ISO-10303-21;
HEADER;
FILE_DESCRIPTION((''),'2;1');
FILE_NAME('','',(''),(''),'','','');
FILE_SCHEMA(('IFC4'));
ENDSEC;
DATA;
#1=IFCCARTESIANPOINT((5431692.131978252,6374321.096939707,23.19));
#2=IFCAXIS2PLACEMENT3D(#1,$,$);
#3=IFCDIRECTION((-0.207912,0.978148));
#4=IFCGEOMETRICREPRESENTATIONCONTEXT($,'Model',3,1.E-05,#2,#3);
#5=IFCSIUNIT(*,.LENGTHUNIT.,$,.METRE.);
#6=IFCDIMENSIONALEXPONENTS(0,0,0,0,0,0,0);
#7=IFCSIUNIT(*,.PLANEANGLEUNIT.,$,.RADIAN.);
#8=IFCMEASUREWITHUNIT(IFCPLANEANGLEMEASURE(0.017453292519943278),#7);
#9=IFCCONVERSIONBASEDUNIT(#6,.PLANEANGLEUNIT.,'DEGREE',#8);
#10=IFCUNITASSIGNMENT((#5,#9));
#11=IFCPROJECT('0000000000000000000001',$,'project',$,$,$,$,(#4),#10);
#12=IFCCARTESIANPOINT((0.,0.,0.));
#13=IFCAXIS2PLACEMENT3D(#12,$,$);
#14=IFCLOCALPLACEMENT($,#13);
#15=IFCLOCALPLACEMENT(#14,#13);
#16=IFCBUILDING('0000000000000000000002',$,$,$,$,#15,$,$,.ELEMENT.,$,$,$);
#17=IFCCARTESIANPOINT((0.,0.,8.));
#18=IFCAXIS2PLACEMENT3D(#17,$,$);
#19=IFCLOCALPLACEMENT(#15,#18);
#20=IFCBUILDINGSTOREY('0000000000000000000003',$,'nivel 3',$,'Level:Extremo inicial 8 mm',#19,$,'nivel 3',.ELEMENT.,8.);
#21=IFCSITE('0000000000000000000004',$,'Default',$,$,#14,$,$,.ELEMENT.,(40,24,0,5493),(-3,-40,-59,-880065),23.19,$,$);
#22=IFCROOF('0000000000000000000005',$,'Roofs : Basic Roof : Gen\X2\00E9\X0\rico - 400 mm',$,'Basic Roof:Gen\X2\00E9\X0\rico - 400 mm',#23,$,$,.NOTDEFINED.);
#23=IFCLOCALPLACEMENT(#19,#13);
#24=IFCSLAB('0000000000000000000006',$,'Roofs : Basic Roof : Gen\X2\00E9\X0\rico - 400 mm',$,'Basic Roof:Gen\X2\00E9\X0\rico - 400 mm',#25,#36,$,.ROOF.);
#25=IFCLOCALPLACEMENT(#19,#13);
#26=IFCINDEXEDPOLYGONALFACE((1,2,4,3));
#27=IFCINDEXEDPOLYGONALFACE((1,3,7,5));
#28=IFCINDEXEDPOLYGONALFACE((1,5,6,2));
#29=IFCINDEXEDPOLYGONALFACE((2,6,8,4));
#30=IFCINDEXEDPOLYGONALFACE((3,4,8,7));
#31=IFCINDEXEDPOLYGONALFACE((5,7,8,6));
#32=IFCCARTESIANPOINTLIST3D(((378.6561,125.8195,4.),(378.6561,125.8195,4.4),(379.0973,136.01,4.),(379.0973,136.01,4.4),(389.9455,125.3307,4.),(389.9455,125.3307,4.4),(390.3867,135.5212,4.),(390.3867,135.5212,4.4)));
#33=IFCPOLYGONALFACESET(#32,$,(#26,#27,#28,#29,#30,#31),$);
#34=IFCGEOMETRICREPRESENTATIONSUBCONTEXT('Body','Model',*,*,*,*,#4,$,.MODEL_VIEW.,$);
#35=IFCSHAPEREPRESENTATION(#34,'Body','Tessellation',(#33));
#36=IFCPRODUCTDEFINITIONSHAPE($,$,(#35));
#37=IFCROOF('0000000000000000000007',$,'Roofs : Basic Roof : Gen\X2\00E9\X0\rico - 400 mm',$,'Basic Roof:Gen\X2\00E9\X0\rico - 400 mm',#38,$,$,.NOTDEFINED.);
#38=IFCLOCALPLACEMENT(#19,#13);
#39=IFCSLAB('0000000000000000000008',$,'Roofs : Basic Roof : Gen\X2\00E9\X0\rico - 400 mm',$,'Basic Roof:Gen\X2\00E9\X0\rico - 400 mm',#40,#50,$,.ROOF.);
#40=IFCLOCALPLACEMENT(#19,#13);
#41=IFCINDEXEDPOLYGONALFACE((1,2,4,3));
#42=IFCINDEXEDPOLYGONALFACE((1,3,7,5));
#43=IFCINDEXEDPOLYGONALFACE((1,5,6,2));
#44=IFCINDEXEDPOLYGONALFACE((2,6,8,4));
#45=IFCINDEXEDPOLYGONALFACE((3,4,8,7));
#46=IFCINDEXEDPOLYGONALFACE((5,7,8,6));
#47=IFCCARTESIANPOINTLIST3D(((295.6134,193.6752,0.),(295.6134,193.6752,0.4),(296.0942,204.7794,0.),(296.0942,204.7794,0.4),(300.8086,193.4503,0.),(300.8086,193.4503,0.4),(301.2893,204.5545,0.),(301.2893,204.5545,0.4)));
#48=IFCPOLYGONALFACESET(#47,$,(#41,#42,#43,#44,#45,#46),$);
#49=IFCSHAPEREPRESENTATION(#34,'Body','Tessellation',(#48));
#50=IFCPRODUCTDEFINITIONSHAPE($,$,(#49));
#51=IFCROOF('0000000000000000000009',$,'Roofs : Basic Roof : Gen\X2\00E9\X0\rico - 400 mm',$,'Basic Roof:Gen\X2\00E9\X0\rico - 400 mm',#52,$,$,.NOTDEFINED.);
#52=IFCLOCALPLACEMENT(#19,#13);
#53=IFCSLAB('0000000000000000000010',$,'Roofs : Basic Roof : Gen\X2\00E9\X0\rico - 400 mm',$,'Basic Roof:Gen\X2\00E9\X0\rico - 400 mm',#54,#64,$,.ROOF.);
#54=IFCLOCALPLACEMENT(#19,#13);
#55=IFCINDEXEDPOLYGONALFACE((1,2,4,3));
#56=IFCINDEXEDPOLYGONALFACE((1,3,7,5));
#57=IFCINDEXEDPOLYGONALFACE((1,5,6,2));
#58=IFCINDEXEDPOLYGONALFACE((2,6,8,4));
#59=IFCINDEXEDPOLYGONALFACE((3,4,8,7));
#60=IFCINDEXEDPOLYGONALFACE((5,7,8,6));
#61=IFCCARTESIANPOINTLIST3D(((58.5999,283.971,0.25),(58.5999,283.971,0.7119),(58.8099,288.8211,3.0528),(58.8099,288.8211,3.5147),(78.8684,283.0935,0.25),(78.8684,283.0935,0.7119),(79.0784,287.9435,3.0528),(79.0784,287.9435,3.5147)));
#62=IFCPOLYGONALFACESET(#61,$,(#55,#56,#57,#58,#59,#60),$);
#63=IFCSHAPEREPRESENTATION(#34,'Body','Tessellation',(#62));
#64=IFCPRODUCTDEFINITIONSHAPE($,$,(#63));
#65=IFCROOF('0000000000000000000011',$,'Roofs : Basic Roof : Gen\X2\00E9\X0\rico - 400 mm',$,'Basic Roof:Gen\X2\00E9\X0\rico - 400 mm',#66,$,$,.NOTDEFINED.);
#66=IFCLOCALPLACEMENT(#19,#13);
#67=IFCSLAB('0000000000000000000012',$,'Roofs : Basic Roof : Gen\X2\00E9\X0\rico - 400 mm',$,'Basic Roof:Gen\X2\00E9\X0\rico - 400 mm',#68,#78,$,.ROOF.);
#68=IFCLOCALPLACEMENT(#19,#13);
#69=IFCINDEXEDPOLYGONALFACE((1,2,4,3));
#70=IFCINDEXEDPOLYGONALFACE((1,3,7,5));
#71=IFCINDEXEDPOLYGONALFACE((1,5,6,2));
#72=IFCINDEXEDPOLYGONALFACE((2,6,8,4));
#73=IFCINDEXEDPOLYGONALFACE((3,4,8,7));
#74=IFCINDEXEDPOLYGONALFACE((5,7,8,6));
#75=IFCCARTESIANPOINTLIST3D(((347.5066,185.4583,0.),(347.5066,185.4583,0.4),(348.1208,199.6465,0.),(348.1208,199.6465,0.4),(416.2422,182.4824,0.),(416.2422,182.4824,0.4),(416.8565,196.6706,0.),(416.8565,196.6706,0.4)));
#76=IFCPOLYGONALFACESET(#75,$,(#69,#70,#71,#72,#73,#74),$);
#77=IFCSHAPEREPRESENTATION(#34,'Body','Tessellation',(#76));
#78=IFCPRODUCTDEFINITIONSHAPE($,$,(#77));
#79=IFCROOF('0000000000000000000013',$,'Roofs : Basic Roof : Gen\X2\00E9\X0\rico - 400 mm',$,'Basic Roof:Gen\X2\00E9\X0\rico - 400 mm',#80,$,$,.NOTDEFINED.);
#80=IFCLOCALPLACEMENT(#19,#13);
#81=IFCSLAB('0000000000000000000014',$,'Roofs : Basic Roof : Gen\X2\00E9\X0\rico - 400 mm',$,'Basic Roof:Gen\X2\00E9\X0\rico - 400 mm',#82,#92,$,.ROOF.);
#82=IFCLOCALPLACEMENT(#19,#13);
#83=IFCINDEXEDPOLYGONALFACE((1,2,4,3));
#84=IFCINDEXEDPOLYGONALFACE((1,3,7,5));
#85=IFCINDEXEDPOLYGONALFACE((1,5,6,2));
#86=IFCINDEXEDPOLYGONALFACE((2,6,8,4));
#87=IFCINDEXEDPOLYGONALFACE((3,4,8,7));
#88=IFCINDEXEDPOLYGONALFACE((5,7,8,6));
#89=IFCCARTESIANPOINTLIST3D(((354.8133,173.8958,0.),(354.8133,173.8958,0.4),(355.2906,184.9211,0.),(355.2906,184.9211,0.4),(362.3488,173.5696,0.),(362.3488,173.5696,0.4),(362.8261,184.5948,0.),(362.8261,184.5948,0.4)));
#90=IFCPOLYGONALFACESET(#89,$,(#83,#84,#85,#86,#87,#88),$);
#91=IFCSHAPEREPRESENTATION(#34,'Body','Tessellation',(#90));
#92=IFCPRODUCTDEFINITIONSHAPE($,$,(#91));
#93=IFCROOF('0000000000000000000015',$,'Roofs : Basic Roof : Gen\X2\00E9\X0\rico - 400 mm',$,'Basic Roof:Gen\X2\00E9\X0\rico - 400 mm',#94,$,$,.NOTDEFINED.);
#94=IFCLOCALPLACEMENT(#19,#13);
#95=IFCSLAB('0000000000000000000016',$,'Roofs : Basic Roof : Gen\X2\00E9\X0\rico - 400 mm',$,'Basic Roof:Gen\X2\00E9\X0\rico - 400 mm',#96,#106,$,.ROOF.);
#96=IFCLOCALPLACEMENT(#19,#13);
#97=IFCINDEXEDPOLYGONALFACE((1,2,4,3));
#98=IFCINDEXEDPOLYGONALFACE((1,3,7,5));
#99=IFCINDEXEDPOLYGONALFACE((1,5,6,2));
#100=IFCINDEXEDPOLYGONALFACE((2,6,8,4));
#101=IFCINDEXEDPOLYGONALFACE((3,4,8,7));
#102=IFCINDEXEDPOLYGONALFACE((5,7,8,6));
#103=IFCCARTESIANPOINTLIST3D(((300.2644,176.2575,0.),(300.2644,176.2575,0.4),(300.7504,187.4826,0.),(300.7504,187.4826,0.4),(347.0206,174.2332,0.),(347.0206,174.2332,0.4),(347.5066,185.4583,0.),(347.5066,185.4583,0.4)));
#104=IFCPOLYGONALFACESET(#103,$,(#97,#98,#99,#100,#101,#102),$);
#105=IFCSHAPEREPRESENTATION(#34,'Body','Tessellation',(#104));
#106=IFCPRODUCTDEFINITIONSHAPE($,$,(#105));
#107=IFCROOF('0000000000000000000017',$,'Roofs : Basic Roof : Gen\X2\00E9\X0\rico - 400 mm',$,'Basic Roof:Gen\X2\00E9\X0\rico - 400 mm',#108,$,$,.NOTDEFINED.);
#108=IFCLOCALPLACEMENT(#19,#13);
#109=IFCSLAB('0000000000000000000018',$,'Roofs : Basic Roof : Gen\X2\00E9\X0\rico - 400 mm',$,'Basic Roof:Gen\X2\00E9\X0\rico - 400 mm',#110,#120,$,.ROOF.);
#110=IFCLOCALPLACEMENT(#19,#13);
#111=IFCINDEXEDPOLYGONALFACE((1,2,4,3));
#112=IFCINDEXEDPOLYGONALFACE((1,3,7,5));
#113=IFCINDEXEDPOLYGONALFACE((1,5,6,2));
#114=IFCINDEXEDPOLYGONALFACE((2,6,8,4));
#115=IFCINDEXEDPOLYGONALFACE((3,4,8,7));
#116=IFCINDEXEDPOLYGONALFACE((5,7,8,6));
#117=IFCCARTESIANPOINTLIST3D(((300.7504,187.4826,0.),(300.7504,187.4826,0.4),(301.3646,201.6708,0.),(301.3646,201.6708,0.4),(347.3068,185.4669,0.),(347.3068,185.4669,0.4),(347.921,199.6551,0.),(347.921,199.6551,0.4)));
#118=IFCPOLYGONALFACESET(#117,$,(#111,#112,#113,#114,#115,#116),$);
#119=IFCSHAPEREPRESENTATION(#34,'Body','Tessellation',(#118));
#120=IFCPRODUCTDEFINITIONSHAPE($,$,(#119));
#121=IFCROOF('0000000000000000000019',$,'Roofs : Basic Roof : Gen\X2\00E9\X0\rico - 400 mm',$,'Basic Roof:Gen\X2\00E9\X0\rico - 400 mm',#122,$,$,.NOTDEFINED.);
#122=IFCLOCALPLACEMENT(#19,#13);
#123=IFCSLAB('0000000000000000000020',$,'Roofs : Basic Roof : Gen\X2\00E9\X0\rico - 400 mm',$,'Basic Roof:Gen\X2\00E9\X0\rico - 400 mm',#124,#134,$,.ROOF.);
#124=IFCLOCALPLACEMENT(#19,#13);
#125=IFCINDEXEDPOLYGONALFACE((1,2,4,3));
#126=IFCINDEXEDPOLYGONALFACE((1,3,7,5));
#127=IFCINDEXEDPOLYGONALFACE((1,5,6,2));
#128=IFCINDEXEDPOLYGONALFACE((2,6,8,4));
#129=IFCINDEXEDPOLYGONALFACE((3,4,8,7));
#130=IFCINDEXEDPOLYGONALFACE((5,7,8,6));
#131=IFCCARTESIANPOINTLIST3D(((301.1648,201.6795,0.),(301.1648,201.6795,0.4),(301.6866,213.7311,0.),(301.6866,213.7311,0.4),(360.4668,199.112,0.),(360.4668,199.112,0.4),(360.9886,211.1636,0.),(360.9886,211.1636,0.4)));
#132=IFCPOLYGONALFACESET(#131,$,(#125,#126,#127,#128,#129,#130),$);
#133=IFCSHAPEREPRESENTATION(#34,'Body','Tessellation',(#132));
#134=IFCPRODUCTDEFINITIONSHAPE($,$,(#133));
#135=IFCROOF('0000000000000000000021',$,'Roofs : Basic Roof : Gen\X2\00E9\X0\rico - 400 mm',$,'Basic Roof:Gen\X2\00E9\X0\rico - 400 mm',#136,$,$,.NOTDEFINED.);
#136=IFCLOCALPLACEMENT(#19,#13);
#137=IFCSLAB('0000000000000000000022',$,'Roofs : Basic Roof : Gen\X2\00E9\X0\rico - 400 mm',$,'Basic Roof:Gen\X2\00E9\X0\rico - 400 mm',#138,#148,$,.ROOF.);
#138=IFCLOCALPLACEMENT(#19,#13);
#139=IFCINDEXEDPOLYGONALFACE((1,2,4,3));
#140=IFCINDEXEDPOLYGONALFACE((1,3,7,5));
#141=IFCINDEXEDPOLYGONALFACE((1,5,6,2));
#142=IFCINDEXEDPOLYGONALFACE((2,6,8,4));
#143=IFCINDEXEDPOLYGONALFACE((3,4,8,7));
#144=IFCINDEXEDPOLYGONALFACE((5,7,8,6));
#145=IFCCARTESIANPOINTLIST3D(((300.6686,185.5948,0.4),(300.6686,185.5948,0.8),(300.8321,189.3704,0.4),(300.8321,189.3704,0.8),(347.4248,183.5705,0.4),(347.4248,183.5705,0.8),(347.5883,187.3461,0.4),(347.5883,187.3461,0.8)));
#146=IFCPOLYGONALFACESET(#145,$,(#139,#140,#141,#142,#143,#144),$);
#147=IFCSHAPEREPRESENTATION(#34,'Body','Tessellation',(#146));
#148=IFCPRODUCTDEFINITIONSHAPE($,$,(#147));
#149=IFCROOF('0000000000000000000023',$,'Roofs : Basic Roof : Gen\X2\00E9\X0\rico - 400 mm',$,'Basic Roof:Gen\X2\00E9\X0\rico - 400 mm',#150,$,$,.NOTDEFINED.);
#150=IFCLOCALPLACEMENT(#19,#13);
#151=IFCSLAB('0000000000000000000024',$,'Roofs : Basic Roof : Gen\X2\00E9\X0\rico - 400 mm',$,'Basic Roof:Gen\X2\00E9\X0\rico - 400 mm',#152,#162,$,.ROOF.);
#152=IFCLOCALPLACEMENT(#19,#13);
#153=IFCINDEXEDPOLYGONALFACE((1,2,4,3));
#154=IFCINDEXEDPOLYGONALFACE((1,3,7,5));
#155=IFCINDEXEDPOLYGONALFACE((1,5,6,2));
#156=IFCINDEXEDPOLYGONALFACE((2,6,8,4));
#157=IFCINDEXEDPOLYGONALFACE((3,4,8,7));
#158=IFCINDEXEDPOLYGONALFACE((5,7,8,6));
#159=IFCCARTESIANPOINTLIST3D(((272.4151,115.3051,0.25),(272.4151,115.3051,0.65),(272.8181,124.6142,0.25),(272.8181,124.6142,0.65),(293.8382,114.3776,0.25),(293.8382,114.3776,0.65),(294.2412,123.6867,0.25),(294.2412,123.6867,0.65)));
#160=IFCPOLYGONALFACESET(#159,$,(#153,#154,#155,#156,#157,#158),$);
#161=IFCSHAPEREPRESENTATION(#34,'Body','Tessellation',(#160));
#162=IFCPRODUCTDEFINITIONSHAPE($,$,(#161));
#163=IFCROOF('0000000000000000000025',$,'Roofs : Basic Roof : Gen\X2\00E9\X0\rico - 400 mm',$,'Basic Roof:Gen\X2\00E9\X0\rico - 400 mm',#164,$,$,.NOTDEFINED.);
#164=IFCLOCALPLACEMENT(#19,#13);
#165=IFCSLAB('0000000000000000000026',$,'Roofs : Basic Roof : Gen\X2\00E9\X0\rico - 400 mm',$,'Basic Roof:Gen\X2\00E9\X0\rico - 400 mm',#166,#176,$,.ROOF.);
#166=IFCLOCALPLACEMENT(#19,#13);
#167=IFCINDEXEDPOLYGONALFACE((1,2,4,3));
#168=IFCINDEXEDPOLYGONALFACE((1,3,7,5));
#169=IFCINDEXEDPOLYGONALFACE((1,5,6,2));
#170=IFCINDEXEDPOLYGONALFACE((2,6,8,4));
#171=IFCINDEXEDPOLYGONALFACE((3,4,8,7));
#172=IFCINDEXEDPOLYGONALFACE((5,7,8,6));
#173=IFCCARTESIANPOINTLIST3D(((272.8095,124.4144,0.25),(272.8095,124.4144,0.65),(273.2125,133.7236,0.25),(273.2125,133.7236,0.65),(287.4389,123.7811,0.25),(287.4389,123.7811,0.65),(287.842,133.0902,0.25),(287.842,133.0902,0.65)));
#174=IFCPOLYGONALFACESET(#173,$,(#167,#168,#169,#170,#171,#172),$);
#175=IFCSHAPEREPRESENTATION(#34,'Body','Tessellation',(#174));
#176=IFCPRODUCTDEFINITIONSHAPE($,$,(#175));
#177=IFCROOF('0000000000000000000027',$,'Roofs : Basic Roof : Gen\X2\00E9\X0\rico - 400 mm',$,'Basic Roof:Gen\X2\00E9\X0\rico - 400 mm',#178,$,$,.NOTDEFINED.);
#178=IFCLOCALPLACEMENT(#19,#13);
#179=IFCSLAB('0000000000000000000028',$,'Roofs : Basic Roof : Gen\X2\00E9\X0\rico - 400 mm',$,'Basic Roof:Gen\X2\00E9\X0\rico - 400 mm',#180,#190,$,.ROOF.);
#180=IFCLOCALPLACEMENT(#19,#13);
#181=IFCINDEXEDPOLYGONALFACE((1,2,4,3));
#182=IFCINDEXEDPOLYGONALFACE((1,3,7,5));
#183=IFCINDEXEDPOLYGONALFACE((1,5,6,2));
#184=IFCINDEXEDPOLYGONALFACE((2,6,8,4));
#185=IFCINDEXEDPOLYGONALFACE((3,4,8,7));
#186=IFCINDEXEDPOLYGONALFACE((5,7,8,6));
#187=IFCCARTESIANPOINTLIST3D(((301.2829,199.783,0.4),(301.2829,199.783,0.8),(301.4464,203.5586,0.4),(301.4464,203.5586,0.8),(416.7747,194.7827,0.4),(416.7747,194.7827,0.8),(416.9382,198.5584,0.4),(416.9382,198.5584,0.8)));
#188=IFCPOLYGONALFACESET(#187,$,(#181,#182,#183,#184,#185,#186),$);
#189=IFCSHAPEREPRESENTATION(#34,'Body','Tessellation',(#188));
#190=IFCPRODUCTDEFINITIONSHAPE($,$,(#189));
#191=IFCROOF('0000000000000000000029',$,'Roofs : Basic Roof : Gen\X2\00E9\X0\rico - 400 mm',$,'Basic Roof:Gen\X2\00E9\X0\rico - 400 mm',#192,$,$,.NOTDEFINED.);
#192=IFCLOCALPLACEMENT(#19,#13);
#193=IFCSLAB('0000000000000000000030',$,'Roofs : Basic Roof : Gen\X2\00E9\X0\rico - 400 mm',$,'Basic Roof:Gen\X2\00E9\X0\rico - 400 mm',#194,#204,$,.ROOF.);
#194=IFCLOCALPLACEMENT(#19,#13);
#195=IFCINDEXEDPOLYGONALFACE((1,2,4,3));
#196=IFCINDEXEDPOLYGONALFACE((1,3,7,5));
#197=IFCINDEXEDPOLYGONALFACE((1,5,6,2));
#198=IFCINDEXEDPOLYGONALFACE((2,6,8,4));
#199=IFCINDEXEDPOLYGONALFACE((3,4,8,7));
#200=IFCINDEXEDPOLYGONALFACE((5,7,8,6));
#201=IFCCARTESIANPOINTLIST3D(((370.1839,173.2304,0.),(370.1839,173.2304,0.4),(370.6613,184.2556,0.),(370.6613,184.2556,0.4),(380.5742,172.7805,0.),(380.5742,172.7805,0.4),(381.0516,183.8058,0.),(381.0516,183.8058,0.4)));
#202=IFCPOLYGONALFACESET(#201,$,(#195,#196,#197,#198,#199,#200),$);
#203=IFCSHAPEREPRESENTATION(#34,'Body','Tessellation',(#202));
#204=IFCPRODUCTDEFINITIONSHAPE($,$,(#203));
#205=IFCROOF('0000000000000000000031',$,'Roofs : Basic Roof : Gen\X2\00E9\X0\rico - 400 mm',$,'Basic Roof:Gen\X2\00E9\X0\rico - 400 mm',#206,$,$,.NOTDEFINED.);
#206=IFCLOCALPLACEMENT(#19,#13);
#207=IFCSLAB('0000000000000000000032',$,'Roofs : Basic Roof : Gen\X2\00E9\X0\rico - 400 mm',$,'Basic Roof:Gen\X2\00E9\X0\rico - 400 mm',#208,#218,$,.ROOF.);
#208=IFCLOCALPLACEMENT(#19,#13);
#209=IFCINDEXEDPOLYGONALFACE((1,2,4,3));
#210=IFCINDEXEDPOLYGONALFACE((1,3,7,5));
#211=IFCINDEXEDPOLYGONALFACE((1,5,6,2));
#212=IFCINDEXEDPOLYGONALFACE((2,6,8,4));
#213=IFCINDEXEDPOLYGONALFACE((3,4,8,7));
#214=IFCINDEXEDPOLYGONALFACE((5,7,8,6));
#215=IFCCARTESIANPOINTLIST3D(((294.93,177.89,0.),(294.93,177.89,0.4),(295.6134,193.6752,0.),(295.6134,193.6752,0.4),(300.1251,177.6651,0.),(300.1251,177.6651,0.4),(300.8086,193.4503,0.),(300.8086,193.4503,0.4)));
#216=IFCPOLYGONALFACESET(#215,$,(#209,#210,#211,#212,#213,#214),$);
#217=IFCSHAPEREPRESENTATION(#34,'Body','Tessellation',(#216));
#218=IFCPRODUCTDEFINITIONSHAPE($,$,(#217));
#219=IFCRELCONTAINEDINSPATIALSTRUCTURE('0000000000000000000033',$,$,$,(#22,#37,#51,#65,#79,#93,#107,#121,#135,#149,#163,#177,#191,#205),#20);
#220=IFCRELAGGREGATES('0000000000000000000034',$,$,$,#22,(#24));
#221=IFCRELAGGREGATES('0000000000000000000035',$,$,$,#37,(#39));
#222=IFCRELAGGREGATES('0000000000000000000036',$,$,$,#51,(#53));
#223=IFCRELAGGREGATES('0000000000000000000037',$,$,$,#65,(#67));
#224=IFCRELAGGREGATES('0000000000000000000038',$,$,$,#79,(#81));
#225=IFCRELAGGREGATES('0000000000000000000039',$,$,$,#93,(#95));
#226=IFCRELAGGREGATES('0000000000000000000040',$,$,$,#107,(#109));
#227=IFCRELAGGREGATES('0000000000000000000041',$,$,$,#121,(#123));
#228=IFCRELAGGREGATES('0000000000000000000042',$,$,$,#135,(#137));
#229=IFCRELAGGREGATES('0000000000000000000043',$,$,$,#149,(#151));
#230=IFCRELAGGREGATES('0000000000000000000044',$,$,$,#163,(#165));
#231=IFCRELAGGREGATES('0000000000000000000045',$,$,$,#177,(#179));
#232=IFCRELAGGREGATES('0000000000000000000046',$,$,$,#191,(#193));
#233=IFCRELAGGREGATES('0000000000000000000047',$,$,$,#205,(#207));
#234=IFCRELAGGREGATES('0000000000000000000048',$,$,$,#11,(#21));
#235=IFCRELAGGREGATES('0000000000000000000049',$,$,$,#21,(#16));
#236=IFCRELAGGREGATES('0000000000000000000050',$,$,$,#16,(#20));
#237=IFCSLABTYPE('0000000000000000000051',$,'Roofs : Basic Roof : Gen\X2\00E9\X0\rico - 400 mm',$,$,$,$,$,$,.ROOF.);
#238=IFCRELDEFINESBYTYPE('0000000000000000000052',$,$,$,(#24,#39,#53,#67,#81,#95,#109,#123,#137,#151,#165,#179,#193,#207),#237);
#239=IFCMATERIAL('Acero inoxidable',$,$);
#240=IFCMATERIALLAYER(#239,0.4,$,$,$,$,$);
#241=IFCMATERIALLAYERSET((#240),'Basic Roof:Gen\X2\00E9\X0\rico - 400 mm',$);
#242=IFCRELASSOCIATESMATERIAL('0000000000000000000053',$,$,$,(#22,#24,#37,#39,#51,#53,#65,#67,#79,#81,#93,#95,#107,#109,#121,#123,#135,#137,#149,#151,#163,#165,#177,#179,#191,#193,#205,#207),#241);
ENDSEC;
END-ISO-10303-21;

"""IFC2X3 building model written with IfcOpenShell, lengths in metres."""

from ifc_helpers import new_model, entity, si_unit, converted_unit, direction, frame, frame_2d, origin, place, context, subcontext, project, spatial, rectangle, extrude, material, layer, layer_set, type_object, element, aggregate, save


model = new_model("IFC2X3")

# Units and contexts
model_context = context("Model", 3, precision=1e-05, world=frame((5431692.131978252, 6374321.096939707, 23.19)), true_north=direction((-0.207912, 0.978148)))
body_context = subcontext(model_context, "Body", "Model", "MODEL_VIEW")
ifc_project = project(units=[si_unit("LENGTHUNIT", "METRE"), converted_unit("PLANEANGLEUNIT", "DEGREE", entity("IfcPlaneAngleMeasure", 0.017453292519943278), si_unit("PLANEANGLEUNIT", "RADIAN"), dimensions=[0, 0, 0, 0, 0, 0, 0])], contexts=[model_context])

# Site, building, storey
site_placement = place(None, origin())
site = spatial("IfcSite", under=ifc_project, at=site_placement, Name="Default", CompositionType="ELEMENT", RefLatitude=(40, 24, 0, 5493), RefLongitude=(-3, -40, -59, -880065), RefElevation=23.19)
building_placement = place(site_placement, origin())
building = spatial("IfcBuilding", under=site, at=building_placement, CompositionType="ELEMENT")
storey_placement = place(building_placement, frame((0.0, 0.0, 8.0)))
storey = spatial("IfcBuildingStorey", under=building, at=storey_placement, Name="nivel 3", ObjectType="Level:Extremo inicial 8 mm", LongName="nivel 3", CompositionType="ELEMENT", Elevation=8.0)

# Roofs, slabs
ifc_material_1 = material(Name="Acero inoxidable")
ifc_layer = layer(ifc_material_1, 0.4)
ifc_layer_set = layer_set([ifc_layer], Name="Basic Roof:Genérico - 400 mm")
roof_1_placement = place(storey_placement, frame((378.6561, 125.3307, 4.0)))
roof_1 = element("IfcRoof", 1, at=roof_1_placement, inside=storey, material=ifc_layer_set, Name="Roofs : Basic Roof : Genérico - 400 mm", ObjectType="Basic Roof:Genérico - 400 mm", ShapeType="NOTDEFINED")
slab_type = type_object("IfcSlabType", Name="Roofs : Basic Roof : Genérico - 400 mm", PredefinedType="ROOF")
slab_1_placement = place(roof_1_placement, origin())
slab_1 = element("IfcSlab", 2, at=slab_1_placement, type_object=slab_type, material=ifc_layer_set, Name="Roofs : Basic Roof : Genérico - 400 mm", ObjectType="Basic Roof:Genérico - 400 mm", PredefinedType="ROOF", context=body_context, shape_type="SweptSolid", body=[
    extrude(rectangle(XDim=10.2, YDim=11.3, at=frame_2d((0.0, 0.0), x_axis=(0.043255, 0.999064))), frame((5.8653, 5.3396, 0.0)), (0.0, 0.0, 1.0), 0.4),
])
aggregate(roof_1, [slab_1])
roof_2_placement = place(storey_placement, frame((295.6134, 193.4503, 0.0)))
roof_2 = element("IfcRoof", 3, at=roof_2_placement, inside=storey, material=ifc_layer_set, Name="Roofs : Basic Roof : Genérico - 400 mm", ObjectType="Basic Roof:Genérico - 400 mm", ShapeType="NOTDEFINED")
slab_2_placement = place(roof_2_placement, origin())
slab_2 = element("IfcSlab", 4, at=slab_2_placement, type_object=slab_type, material=ifc_layer_set, Name="Roofs : Basic Roof : Genérico - 400 mm", ObjectType="Basic Roof:Genérico - 400 mm", PredefinedType="ROOF", context=body_context, shape_type="SweptSolid", body=[
    extrude(rectangle(XDim=11.1146, YDim=5.2, at=frame_2d((0.0, 0.0), x_axis=(-0.043255, -0.999064))), frame((2.8379, 5.6646, 0.0)), (0.0, 0.0, 1.0), 0.4),
])
aggregate(roof_2, [slab_2])

# Roof, slab
roof_3_placement = place(storey_placement, frame((58.5999, 283.0935, 0.25)))
roof_3 = element("IfcRoof", 5, at=roof_3_placement, inside=storey, material=ifc_layer_set, Name="Roofs : Basic Roof : Genérico - 400 mm", ObjectType="Basic Roof:Genérico - 400 mm", ShapeType="NOTDEFINED")
slab_3_placement = place(roof_3_placement, origin())
slab_3 = element("IfcSlab", 6, at=slab_3_placement, type_object=slab_type, material=ifc_layer_set, Name="Roofs : Basic Roof : Genérico - 400 mm", ObjectType="Basic Roof:Genérico - 400 mm", PredefinedType="ROOF", context=body_context, shape_type="SweptSolid", body=[
    extrude(rectangle(XDim=5.6056, YDim=20.2874, at=frame_2d((0.0, 0.0), x_axis=(0.037468, 0.999298))), frame((10.2392, 2.8638, 1.4014), z_axis=(-0.021627, -0.499532, 0.866025), x_axis=(0.999766, -0.010806, 0.018734)), (0.018734, 0.499649, 0.866025), 0.4619),
])
aggregate(roof_3, [slab_3])

# Roofs, slabs
roof_4_placement = place(storey_placement, frame((347.5066, 182.4824, 0.0)))
roof_4 = element("IfcRoof", 7, at=roof_4_placement, inside=storey, material=ifc_layer_set, Name="Roofs : Basic Roof : Genérico - 400 mm", ObjectType="Basic Roof:Genérico - 400 mm", ShapeType="NOTDEFINED")
slab_4_placement = place(roof_4_placement, origin())
slab_4 = element("IfcSlab", 8, at=slab_4_placement, type_object=slab_type, material=ifc_layer_set, Name="Roofs : Basic Roof : Genérico - 400 mm", ObjectType="Basic Roof:Genérico - 400 mm", PredefinedType="ROOF", context=body_context, shape_type="SweptSolid", body=[
    extrude(rectangle(XDim=14.2015, YDim=68.8, at=frame_2d((0.0, 0.0), x_axis=(0.043255, 0.999064))), frame((34.6749, 8.5821, 0.0)), (0.0, 0.0, 1.0), 0.4),
])
aggregate(roof_4, [slab_4])
roof_5_placement = place(storey_placement, frame((354.8133, 173.5696, 0.0)))
roof_5 = element("IfcRoof", 9, at=roof_5_placement, inside=storey, material=ifc_layer_set, Name="Roofs : Basic Roof : Genérico - 400 mm", ObjectType="Basic Roof:Genérico - 400 mm", ShapeType="NOTDEFINED")
slab_5_placement = place(roof_5_placement, origin())
slab_5 = element("IfcSlab", 10, at=slab_5_placement, type_object=slab_type, material=ifc_layer_set, Name="Roofs : Basic Roof : Genérico - 400 mm", ObjectType="Basic Roof:Genérico - 400 mm", PredefinedType="ROOF", context=body_context, shape_type="SweptSolid", body=[
    extrude(rectangle(XDim=11.0356, YDim=7.5425, at=frame_2d((0.0, 0.0), x_axis=(0.043255, 0.999064))), frame((4.0064, 5.6758, 0.0)), (0.0, 0.0, 1.0), 0.4),
])
aggregate(roof_5, [slab_5])
roof_6_placement = place(storey_placement, frame((300.2644, 174.2332, 0.0)))
roof_6 = element("IfcRoof", 11, at=roof_6_placement, inside=storey, material=ifc_layer_set, Name="Roofs : Basic Roof : Genérico - 400 mm", ObjectType="Basic Roof:Genérico - 400 mm", ShapeType="NOTDEFINED")
slab_6_placement = place(roof_6_placement, origin())
slab_6 = element("IfcSlab", 12, at=slab_6_placement, type_object=slab_type, material=ifc_layer_set, Name="Roofs : Basic Roof : Genérico - 400 mm", ObjectType="Basic Roof:Genérico - 400 mm", PredefinedType="ROOF", context=body_context, shape_type="SweptSolid", body=[
    extrude(rectangle(XDim=11.2356, YDim=46.8, at=frame_2d((0.0, 0.0), x_axis=(0.043255, 0.999064))), frame((23.6211, 6.6247, 0.0)), (0.0, 0.0, 1.0), 0.4),
])
aggregate(roof_6, [slab_6])
roof_7_placement = place(storey_placement, frame((300.7504, 185.4669, 0.0)))
roof_7 = element("IfcRoof", 13, at=roof_7_placement, inside=storey, material=ifc_layer_set, Name="Roofs : Basic Roof : Genérico - 400 mm", ObjectType="Basic Roof:Genérico - 400 mm", ShapeType="NOTDEFINED")
slab_7_placement = place(roof_7_placement, origin())
slab_7 = element("IfcSlab", 14, at=slab_7_placement, type_object=slab_type, material=ifc_layer_set, Name="Roofs : Basic Roof : Genérico - 400 mm", ObjectType="Basic Roof:Genérico - 400 mm", PredefinedType="ROOF", context=body_context, shape_type="SweptSolid", body=[
    extrude(rectangle(XDim=14.2015, YDim=46.6, at=frame_2d((0.0, 0.0), x_axis=(0.043255, 0.999064))), frame((23.5853, 8.1019, 0.0)), (0.0, 0.0, 1.0), 0.4),
])
aggregate(roof_7, [slab_7])
roof_8_placement = place(storey_placement, frame((301.1648, 199.112, 0.0)))
roof_8 = element("IfcRoof", 15, at=roof_8_placement, inside=storey, material=ifc_layer_set, Name="Roofs : Basic Roof : Genérico - 400 mm", ObjectType="Basic Roof:Genérico - 400 mm", ShapeType="NOTDEFINED")
slab_8_placement = place(roof_8_placement, origin())
slab_8 = element("IfcSlab", 16, at=slab_8_placement, type_object=slab_type, material=ifc_layer_set, Name="Roofs : Basic Roof : Genérico - 400 mm", ObjectType="Basic Roof:Genérico - 400 mm", PredefinedType="ROOF", context=body_context, shape_type="SweptSolid", body=[
    extrude(rectangle(XDim=12.0629, YDim=59.3575, at=frame_2d((0.0, 0.0), x_axis=(0.043255, 0.999064))), frame((29.9119, 7.3096, 0.0)), (0.0, 0.0, 1.0), 0.4),
])
aggregate(roof_8, [slab_8])
roof_9_placement = place(storey_placement, frame((300.6686, 183.5705, 0.4)))
roof_9 = element("IfcRoof", 17, at=roof_9_placement, inside=storey, material=ifc_layer_set, Name="Roofs : Basic Roof : Genérico - 400 mm", ObjectType="Basic Roof:Genérico - 400 mm", ShapeType="NOTDEFINED")
slab_9_placement = place(roof_9_placement, origin())
slab_9 = element("IfcSlab", 18, at=slab_9_placement, type_object=slab_type, material=ifc_layer_set, Name="Roofs : Basic Roof : Genérico - 400 mm", ObjectType="Basic Roof:Genérico - 400 mm", PredefinedType="ROOF", context=body_context, shape_type="SweptSolid", body=[
    extrude(rectangle(XDim=3.7792, YDim=46.8, at=frame_2d((0.0, 0.0), x_axis=(0.043255, 0.999064))), frame((23.4598, 2.9, 0.0)), (0.0, 0.0, 1.0), 0.4),
])
aggregate(roof_9, [slab_9])
roof_10_placement = place(storey_placement, frame((272.4151, 114.3776, 0.25)))
roof_10 = element("IfcRoof", 19, at=roof_10_placement, inside=storey, material=ifc_layer_set, Name="Roofs : Basic Roof : Genérico - 400 mm", ObjectType="Basic Roof:Genérico - 400 mm", ShapeType="NOTDEFINED")
slab_10_placement = place(roof_10_placement, origin())
slab_10 = element("IfcSlab", 20, at=slab_10_placement, type_object=slab_type, material=ifc_layer_set, Name="Roofs : Basic Roof : Genérico - 400 mm", ObjectType="Basic Roof:Genérico - 400 mm", PredefinedType="ROOF", context=body_context, shape_type="SweptSolid", body=[
    extrude(rectangle(XDim=21.4432, YDim=9.3179, at=frame_2d((0.0, 0.0), x_axis=(-0.999064, 0.043255))), frame((10.9131, 5.1183, 0.0)), (0.0, 0.0, 1.0), 0.4),
])
aggregate(roof_10, [slab_10])
roof_11_placement = place(storey_placement, frame((272.8095, 123.7811, 0.25)))
roof_11 = element("IfcRoof", 21, at=roof_11_placement, inside=storey, material=ifc_layer_set, Name="Roofs : Basic Roof : Genérico - 400 mm", ObjectType="Basic Roof:Genérico - 400 mm", ShapeType="NOTDEFINED")
slab_11_placement = place(roof_11_placement, origin())
slab_11 = element("IfcSlab", 22, at=slab_11_placement, type_object=slab_type, material=ifc_layer_set, Name="Roofs : Basic Roof : Genérico - 400 mm", ObjectType="Basic Roof:Genérico - 400 mm", PredefinedType="ROOF", context=body_context, shape_type="SweptSolid", body=[
    extrude(rectangle(XDim=14.6432, YDim=9.3179, at=frame_2d((0.0, 0.0), x_axis=(-0.999064, 0.043255))), frame((7.5162, 4.9713, 0.0)), (0.0, 0.0, 1.0), 0.4),
])
aggregate(roof_11, [slab_11])
roof_12_placement = place(storey_placement, frame((301.2829, 194.7827, 0.4)))
roof_12 = element("IfcRoof", 23, at=roof_12_placement, inside=storey, material=ifc_layer_set, Name="Roofs : Basic Roof : Genérico - 400 mm", ObjectType="Basic Roof:Genérico - 400 mm", ShapeType="NOTDEFINED")
slab_12_placement = place(roof_12_placement, origin())
slab_12 = element("IfcSlab", 24, at=slab_12_placement, type_object=slab_type, material=ifc_layer_set, Name="Roofs : Basic Roof : Genérico - 400 mm", ObjectType="Basic Roof:Genérico - 400 mm", PredefinedType="ROOF", context=body_context, shape_type="SweptSolid", body=[
    extrude(rectangle(XDim=3.7792, YDim=115.6, at=frame_2d((0.0, 0.0), x_axis=(0.043255, 0.999064))), frame((57.8276, 4.3879, 0.0)), (0.0, 0.0, 1.0), 0.4),
])
aggregate(roof_12, [slab_12])
roof_13_placement = place(storey_placement, frame((370.1839, 172.7805, 0.0)))
roof_13 = element("IfcRoof", 25, at=roof_13_placement, inside=storey, material=ifc_layer_set, Name="Roofs : Basic Roof : Genérico - 400 mm", ObjectType="Basic Roof:Genérico - 400 mm", ShapeType="NOTDEFINED")
slab_13_placement = place(roof_13_placement, origin())
slab_13 = element("IfcSlab", 26, at=slab_13_placement, type_object=slab_type, material=ifc_layer_set, Name="Roofs : Basic Roof : Genérico - 400 mm", ObjectType="Basic Roof:Genérico - 400 mm", PredefinedType="ROOF", context=body_context, shape_type="SweptSolid", body=[
    extrude(rectangle(XDim=11.0356, YDim=10.4, at=frame_2d((0.0, 0.0), x_axis=(0.043255, 0.999064))), frame((5.4338, 5.7376, 0.0)), (0.0, 0.0, 1.0), 0.4),
])
aggregate(roof_13, [slab_13])
roof_14_placement = place(storey_placement, frame((294.93, 177.6651, 0.0)))
roof_14 = element("IfcRoof", 27, at=roof_14_placement, inside=storey, material=ifc_layer_set, Name="Roofs : Basic Roof : Genérico - 400 mm", ObjectType="Basic Roof:Genérico - 400 mm", ShapeType="NOTDEFINED")
slab_14_placement = place(roof_14_placement, origin())
slab_14 = element("IfcSlab", 28, at=slab_14_placement, type_object=slab_type, material=ifc_layer_set, Name="Roofs : Basic Roof : Genérico - 400 mm", ObjectType="Basic Roof:Genérico - 400 mm", PredefinedType="ROOF", context=body_context, shape_type="SweptSolid", body=[
    extrude(rectangle(XDim=15.8, YDim=5.2, at=frame_2d((0.0, 0.0), x_axis=(-0.043255, -0.999064))), frame((2.9393, 8.0051, 0.0)), (0.0, 0.0, 1.0), 0.4),
])
aggregate(roof_14, [slab_14])

save(model, "model.ifc")
